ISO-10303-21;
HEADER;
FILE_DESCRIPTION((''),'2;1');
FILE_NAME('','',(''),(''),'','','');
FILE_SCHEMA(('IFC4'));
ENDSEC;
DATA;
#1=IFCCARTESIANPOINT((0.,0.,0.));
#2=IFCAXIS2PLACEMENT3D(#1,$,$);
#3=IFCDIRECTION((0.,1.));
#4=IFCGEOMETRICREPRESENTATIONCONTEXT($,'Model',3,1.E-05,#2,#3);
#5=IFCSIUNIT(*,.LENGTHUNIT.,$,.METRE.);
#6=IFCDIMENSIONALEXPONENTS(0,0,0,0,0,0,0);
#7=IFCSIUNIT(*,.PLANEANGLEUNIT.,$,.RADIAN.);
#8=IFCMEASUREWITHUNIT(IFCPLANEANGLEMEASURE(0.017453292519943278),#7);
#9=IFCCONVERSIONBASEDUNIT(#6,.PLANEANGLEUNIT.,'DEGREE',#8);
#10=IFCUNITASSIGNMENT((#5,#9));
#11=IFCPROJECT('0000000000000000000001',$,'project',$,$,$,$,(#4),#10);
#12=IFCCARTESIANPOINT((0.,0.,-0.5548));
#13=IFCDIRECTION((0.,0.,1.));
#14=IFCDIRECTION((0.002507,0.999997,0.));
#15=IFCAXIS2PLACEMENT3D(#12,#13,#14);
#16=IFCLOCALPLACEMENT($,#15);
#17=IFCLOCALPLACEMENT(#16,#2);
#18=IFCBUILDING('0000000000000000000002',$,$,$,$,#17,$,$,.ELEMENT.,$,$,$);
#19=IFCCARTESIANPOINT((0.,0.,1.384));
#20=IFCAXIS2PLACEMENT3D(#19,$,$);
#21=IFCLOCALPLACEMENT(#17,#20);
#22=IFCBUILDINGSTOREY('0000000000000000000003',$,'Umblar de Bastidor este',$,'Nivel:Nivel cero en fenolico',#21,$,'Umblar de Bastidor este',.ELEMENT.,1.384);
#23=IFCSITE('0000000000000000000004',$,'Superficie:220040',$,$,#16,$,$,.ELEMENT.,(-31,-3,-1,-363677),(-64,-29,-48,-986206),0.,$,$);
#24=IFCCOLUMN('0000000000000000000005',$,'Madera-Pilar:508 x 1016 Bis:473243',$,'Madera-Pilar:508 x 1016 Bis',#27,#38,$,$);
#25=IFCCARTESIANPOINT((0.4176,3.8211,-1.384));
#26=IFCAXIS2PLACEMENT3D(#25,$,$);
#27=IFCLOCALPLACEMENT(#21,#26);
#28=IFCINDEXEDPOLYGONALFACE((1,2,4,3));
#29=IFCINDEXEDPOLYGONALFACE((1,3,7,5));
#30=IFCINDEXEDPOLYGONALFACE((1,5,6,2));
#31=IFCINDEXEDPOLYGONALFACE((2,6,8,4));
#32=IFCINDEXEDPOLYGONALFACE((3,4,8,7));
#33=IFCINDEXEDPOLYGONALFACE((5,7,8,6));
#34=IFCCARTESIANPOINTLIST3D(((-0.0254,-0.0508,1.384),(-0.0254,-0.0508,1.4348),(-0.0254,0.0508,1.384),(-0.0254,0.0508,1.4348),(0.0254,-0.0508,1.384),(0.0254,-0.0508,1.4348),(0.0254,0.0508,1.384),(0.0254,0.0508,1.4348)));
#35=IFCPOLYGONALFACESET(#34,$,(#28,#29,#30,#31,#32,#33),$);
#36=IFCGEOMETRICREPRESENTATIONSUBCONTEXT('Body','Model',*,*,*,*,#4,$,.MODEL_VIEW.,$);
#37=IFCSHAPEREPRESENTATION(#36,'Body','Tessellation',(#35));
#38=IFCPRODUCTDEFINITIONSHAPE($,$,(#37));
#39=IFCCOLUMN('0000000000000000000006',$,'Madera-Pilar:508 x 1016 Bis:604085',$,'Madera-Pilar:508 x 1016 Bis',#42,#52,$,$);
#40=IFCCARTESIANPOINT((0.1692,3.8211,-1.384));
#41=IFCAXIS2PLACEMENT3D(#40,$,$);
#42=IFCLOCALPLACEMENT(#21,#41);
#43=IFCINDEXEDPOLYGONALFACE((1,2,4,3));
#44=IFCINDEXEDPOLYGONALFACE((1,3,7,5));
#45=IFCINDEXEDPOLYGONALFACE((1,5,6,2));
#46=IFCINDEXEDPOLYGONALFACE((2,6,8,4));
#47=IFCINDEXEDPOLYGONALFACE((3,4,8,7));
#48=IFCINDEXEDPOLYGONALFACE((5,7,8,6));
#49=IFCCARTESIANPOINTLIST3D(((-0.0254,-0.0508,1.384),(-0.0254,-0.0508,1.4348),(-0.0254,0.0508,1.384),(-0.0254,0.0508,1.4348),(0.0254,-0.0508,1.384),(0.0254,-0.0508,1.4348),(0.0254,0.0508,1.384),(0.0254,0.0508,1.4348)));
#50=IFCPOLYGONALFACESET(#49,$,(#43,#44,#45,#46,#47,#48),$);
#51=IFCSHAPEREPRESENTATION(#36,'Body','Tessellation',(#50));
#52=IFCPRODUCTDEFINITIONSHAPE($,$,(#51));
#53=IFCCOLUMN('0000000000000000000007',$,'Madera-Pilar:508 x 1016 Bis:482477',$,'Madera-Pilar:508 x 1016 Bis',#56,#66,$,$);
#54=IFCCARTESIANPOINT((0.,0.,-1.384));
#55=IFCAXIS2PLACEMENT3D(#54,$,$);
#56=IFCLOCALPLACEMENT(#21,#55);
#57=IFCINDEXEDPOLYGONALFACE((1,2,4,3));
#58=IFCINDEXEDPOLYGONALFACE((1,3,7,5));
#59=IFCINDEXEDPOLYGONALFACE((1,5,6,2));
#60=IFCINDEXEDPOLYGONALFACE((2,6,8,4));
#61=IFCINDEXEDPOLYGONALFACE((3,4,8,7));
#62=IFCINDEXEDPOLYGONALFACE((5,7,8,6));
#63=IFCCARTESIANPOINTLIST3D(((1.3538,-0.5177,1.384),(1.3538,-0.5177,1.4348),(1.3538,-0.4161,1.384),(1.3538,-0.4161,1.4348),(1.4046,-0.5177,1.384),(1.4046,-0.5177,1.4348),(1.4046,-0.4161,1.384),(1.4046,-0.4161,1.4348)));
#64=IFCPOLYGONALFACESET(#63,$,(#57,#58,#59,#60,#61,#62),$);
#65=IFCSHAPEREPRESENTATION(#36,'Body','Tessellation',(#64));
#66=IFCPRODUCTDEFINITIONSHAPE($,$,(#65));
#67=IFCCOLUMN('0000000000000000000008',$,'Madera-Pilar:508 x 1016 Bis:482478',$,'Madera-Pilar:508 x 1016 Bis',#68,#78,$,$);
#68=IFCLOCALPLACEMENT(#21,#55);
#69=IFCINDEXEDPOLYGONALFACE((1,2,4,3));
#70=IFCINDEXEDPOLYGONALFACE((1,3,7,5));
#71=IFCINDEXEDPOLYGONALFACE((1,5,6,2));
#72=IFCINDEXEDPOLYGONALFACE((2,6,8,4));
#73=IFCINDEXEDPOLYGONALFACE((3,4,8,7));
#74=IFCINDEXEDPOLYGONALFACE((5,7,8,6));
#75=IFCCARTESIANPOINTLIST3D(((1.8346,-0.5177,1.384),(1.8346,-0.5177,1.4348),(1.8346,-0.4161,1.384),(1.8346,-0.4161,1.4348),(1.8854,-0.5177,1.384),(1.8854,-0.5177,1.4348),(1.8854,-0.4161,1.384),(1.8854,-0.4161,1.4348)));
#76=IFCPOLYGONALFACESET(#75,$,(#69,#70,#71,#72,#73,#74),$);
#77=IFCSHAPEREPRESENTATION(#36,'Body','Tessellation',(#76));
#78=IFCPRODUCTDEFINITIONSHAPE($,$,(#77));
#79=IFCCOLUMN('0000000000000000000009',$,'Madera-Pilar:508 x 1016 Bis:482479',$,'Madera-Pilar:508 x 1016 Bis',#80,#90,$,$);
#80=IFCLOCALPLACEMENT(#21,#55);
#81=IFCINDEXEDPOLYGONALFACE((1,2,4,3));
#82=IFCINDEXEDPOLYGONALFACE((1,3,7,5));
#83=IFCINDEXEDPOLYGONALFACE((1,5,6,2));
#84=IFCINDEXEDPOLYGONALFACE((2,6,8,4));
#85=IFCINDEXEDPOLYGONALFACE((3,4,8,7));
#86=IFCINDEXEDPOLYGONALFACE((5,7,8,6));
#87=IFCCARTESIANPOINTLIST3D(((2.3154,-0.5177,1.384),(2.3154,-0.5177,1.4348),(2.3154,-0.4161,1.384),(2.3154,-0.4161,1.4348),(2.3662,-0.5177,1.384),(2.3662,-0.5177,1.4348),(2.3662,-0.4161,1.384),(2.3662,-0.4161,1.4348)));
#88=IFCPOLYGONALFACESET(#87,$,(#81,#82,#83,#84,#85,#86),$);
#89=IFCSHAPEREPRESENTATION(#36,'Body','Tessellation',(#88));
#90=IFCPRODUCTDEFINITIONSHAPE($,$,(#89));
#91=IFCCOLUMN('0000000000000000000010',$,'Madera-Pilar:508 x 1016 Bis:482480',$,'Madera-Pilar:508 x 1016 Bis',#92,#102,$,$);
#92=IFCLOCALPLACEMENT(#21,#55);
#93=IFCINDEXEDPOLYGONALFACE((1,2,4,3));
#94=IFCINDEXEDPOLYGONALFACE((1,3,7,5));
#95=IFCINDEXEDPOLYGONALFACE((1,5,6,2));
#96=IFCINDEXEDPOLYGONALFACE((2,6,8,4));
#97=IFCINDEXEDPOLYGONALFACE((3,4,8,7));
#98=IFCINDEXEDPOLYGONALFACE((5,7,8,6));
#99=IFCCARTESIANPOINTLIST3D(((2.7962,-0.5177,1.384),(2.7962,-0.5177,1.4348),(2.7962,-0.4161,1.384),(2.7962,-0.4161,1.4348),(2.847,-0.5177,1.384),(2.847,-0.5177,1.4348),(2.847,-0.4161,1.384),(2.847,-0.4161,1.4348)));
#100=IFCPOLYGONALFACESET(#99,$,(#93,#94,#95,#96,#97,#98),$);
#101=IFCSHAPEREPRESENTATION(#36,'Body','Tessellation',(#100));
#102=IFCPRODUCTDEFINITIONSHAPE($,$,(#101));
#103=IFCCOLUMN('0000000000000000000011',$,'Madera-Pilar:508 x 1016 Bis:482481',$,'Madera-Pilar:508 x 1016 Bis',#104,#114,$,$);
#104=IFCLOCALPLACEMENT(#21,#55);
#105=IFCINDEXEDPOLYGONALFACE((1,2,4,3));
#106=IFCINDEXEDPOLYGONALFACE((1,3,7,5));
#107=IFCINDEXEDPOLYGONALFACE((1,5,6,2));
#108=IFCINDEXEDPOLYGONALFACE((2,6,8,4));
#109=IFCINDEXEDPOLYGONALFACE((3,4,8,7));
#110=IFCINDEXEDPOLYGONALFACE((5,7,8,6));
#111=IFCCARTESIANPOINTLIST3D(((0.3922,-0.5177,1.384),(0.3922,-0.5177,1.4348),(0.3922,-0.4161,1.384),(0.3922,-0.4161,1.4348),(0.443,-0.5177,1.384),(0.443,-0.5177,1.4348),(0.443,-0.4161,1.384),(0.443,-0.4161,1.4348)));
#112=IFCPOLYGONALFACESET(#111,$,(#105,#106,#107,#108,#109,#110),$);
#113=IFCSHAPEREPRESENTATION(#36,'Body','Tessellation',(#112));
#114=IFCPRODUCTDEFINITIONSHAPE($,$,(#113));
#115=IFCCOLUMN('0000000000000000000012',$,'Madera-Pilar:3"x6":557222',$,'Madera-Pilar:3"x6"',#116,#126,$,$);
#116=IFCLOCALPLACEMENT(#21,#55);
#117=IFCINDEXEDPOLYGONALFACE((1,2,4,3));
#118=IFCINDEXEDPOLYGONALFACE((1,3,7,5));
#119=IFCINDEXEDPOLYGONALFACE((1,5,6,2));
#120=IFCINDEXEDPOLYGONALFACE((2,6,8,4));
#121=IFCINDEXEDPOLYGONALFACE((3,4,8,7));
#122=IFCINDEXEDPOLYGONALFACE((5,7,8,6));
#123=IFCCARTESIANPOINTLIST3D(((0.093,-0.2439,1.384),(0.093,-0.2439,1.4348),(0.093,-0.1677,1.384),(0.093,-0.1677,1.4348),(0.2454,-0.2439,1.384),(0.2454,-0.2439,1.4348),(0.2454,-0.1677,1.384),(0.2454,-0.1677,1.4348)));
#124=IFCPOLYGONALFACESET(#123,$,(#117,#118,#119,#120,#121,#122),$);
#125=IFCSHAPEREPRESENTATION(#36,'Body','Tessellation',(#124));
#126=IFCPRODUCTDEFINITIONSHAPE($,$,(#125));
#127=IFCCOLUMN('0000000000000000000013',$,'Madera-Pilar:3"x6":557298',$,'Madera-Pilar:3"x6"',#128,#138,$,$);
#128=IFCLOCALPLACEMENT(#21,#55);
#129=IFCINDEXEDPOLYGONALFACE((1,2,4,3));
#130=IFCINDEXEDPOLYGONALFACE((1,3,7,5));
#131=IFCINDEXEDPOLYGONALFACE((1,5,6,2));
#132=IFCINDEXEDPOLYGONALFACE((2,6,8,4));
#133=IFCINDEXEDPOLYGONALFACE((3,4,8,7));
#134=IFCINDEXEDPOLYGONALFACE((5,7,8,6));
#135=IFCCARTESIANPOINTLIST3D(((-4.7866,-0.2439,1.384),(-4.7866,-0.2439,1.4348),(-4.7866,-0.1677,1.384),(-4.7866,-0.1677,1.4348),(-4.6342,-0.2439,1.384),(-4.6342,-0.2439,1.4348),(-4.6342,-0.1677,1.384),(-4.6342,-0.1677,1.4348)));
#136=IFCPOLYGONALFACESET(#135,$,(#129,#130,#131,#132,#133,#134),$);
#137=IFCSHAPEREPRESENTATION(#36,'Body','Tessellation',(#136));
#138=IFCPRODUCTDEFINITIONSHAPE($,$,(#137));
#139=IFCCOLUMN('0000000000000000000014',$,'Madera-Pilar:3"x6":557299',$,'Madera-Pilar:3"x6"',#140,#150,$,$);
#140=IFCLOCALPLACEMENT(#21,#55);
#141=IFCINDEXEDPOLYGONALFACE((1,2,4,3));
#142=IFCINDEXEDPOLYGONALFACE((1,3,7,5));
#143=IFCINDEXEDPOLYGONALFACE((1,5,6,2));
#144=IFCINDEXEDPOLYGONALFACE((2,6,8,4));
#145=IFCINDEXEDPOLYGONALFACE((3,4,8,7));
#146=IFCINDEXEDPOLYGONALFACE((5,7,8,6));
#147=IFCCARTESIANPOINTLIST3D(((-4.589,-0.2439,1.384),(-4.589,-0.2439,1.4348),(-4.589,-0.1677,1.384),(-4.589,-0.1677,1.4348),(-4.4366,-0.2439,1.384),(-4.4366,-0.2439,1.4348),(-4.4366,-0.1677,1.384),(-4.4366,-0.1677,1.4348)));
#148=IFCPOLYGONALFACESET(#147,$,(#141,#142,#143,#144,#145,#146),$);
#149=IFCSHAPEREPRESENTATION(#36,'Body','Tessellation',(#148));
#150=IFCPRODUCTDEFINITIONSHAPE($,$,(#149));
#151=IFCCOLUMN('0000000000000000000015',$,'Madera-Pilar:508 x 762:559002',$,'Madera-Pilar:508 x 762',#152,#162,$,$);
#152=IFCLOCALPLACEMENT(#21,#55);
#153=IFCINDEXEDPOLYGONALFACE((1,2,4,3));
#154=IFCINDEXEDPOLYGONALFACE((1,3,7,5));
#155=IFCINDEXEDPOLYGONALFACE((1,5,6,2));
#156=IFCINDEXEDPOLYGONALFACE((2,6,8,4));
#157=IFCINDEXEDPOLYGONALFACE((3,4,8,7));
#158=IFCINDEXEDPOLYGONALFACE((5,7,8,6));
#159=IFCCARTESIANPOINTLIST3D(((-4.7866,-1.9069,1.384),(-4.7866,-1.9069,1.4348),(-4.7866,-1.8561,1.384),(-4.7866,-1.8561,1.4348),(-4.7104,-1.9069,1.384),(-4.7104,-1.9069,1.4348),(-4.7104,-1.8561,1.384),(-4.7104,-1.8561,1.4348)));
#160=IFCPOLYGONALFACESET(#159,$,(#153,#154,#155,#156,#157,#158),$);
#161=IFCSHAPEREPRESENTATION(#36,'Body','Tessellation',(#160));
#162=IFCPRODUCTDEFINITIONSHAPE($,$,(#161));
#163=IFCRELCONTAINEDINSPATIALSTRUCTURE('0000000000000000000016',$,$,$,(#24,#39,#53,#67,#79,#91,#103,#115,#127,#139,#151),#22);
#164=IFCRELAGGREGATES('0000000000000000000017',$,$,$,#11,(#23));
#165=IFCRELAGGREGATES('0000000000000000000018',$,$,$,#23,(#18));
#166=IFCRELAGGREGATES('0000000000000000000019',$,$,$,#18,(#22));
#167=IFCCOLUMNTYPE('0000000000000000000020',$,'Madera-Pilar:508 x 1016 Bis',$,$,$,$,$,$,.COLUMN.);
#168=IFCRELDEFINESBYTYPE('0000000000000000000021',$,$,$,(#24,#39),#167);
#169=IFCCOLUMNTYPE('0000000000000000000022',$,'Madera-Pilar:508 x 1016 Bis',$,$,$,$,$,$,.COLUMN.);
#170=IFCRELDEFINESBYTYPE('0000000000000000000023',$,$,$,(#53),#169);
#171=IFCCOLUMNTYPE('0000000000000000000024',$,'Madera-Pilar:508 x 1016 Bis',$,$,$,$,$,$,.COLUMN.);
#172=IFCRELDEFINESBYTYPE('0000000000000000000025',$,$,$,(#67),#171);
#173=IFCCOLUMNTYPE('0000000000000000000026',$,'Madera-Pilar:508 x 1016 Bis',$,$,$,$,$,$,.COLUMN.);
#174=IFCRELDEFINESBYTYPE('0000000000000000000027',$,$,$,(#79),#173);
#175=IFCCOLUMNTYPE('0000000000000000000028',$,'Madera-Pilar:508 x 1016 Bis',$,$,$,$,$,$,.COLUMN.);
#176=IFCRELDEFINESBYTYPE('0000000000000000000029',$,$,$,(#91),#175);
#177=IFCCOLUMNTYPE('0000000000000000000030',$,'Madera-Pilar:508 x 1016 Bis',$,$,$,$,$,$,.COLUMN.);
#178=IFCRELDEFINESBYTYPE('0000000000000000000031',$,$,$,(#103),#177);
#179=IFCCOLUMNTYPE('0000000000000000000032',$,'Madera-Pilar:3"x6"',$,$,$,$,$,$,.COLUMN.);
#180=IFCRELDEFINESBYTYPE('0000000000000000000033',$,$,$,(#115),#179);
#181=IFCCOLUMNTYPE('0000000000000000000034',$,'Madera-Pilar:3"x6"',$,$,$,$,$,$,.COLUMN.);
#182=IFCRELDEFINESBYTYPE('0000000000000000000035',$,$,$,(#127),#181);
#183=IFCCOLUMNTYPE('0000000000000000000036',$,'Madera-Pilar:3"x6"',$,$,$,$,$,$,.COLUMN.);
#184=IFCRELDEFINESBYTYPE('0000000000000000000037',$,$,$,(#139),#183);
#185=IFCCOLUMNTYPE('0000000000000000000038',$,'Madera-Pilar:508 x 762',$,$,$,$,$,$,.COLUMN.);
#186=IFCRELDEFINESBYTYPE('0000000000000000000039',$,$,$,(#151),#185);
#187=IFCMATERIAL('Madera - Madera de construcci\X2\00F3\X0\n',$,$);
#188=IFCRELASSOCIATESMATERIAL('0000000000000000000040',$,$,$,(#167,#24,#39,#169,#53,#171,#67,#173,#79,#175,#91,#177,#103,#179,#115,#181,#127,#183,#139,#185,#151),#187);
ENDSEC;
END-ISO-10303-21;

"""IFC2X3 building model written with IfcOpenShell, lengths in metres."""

from ifc_helpers import new_model, entity, si_unit, converted_unit, direction, frame, frame_2d, origin, origin_2d_with_axis, place, context, subcontext, project, spatial, rectangle, extrude, source, transform, mapped, material, type_object, type_shapes, element, save


model = new_model("IFC2X3")

# Units and contexts
model_context = context("Model", 3, precision=1e-05, world=origin(), true_north=direction((0.0, 1.0)))
body_context = subcontext(model_context, "Body", "Model", "MODEL_VIEW")
ifc_project = project(units=[si_unit("LENGTHUNIT", "METRE"), converted_unit("PLANEANGLEUNIT", "DEGREE", entity("IfcPlaneAngleMeasure", 0.017453292519943278), si_unit("PLANEANGLEUNIT", "RADIAN"), dimensions=[0, 0, 0, 0, 0, 0, 0])], contexts=[model_context])

# Site, building, storey
site_placement = place(None, frame((0.0, 0.0, -0.5548), z_axis=(0.0, 0.0, 1.0), x_axis=(0.002507, 0.999997, 0.0)))
site = spatial("IfcSite", under=ifc_project, at=site_placement, Name="Superficie:220040", CompositionType="ELEMENT", RefLatitude=(-31, -3, -1, -363677), RefLongitude=(-64, -29, -48, -986206), RefElevation=0.0)
building_placement = place(site_placement, origin())
building = spatial("IfcBuilding", under=site, at=building_placement, CompositionType="ELEMENT")
storey_placement = place(building_placement, frame((0.0, 0.0, 1.384)))
storey = spatial("IfcBuildingStorey", under=building, at=storey_placement, Name="Umblar de Bastidor este", ObjectType="Nivel:Nivel cero en fenolico", LongName="Umblar de Bastidor este", CompositionType="ELEMENT", Elevation=1.384)

# Columns
ifc_material_1 = material(Name="Madera - Madera de construcción")
column_type_1 = type_object("IfcColumnType", Name="Madera-Pilar:508 x 1016 Bis", PredefinedType="COLUMN", material=ifc_material_1)
shared_shape_1 = source(origin(), body_context, "Body", "SweptSolid", [
    extrude(rectangle(XDim=0.0508, YDim=0.1016, at=origin_2d_with_axis()), frame((0.0, 0.0, 1.384), z_axis=(0.0, 0.0, 1.0), x_axis=(-1.0, 0.0, 0.0)), (0.0, 0.0, 1.0), 0.0508),
])
type_shapes(column_type_1, [shared_shape_1])
for number, where, name in (
    (1, (0.4176, 3.8211, -1.384), "Madera-Pilar:508 x 1016 Bis:473243"),
    (2, (0.1692, 3.8211, -1.384), "Madera-Pilar:508 x 1016 Bis:604085"),
):
    element("IfcColumn", number, at=place(storey_placement, frame(where)), inside=storey, type_object=column_type_1, material=ifc_material_1, Name=name, ObjectType="Madera-Pilar:508 x 1016 Bis", context=body_context, shape_type="MappedRepresentation", body=[
        mapped(shared_shape_1, transform((0.0, 0.0, 0.0), scale=1.0)),
    ])
column_type_2 = type_object("IfcColumnType", Name="Madera-Pilar:508 x 1016 Bis", PredefinedType="COLUMN", material=ifc_material_1)
shared_shape_2 = source(origin(), body_context, "Body", "SweptSolid", [
    extrude(rectangle(XDim=0.0508, YDim=0.1016, at=frame_2d((0.0, 0.0), x_axis=(1.0, 0.0))), frame((1.3792, -0.4669, 1.384)), (0.0, 0.0, 1.0), 0.0508),
])
type_shapes(column_type_2, [shared_shape_2])
column_1_placement = place(storey_placement, frame((0.0, 0.0, -1.384)))
element("IfcColumn", 3, at=column_1_placement, inside=storey, type_object=column_type_2, material=ifc_material_1, Name="Madera-Pilar:508 x 1016 Bis:482477", ObjectType="Madera-Pilar:508 x 1016 Bis", context=body_context, shape_type="MappedRepresentation", body=[
    mapped(shared_shape_2, transform((0.0, 0.0, 0.0), scale=1.0)),
])
column_type_3 = type_object("IfcColumnType", Name="Madera-Pilar:508 x 1016 Bis", PredefinedType="COLUMN", material=ifc_material_1)
shared_shape_3 = source(origin(), body_context, "Body", "SweptSolid", [
    extrude(rectangle(XDim=0.0508, YDim=0.1016, at=frame_2d((0.0, 0.0), x_axis=(1.0, 0.0))), frame((1.86, -0.4669, 1.384)), (0.0, 0.0, 1.0), 0.0508),
])
type_shapes(column_type_3, [shared_shape_3])
column_2_placement = place(storey_placement, frame((0.0, 0.0, -1.384)))
element("IfcColumn", 4, at=column_2_placement, inside=storey, type_object=column_type_3, material=ifc_material_1, Name="Madera-Pilar:508 x 1016 Bis:482478", ObjectType="Madera-Pilar:508 x 1016 Bis", context=body_context, shape_type="MappedRepresentation", body=[
    mapped(shared_shape_3, transform((0.0, 0.0, 0.0), scale=1.0)),
])
column_type_4 = type_object("IfcColumnType", Name="Madera-Pilar:508 x 1016 Bis", PredefinedType="COLUMN", material=ifc_material_1)
shared_shape_4 = source(origin(), body_context, "Body", "SweptSolid", [
    extrude(rectangle(XDim=0.0508, YDim=0.1016, at=frame_2d((0.0, 0.0), x_axis=(1.0, 0.0))), frame((2.3408, -0.4669, 1.384)), (0.0, 0.0, 1.0), 0.0508),
])
type_shapes(column_type_4, [shared_shape_4])
column_3_placement = place(storey_placement, frame((0.0, 0.0, -1.384)))
element("IfcColumn", 5, at=column_3_placement, inside=storey, type_object=column_type_4, material=ifc_material_1, Name="Madera-Pilar:508 x 1016 Bis:482479", ObjectType="Madera-Pilar:508 x 1016 Bis", context=body_context, shape_type="MappedRepresentation", body=[
    mapped(shared_shape_4, transform((0.0, 0.0, 0.0), scale=1.0)),
])
column_type_5 = type_object("IfcColumnType", Name="Madera-Pilar:508 x 1016 Bis", PredefinedType="COLUMN", material=ifc_material_1)
shared_shape_5 = source(origin(), body_context, "Body", "SweptSolid", [
    extrude(rectangle(XDim=0.0508, YDim=0.1016, at=frame_2d((0.0, 0.0), x_axis=(1.0, 0.0))), frame((2.8216, -0.4669, 1.384)), (0.0, 0.0, 1.0), 0.0508),
])
type_shapes(column_type_5, [shared_shape_5])
column_4_placement = place(storey_placement, frame((0.0, 0.0, -1.384)))
element("IfcColumn", 6, at=column_4_placement, inside=storey, type_object=column_type_5, material=ifc_material_1, Name="Madera-Pilar:508 x 1016 Bis:482480", ObjectType="Madera-Pilar:508 x 1016 Bis", context=body_context, shape_type="MappedRepresentation", body=[
    mapped(shared_shape_5, transform((0.0, 0.0, 0.0), scale=1.0)),
])
column_type_6 = type_object("IfcColumnType", Name="Madera-Pilar:508 x 1016 Bis", PredefinedType="COLUMN", material=ifc_material_1)
shared_shape_6 = source(origin(), body_context, "Body", "SweptSolid", [
    extrude(rectangle(XDim=0.0508, YDim=0.1016, at=frame_2d((0.0, 0.0), x_axis=(1.0, 0.0))), frame((0.4176, -0.4669, 1.384)), (0.0, 0.0, 1.0), 0.0508),
])
type_shapes(column_type_6, [shared_shape_6])
column_5_placement = place(storey_placement, frame((0.0, 0.0, -1.384)))
element("IfcColumn", 7, at=column_5_placement, inside=storey, type_object=column_type_6, material=ifc_material_1, Name="Madera-Pilar:508 x 1016 Bis:482481", ObjectType="Madera-Pilar:508 x 1016 Bis", context=body_context, shape_type="MappedRepresentation", body=[
    mapped(shared_shape_6, transform((0.0, 0.0, 0.0), scale=1.0)),
])
column_type_7 = type_object("IfcColumnType", Name="Madera-Pilar:3\"x6\"", PredefinedType="COLUMN", material=ifc_material_1)
shared_shape_7 = source(origin(), body_context, "Body", "SweptSolid", [
    extrude(rectangle(XDim=0.1524, YDim=0.0762, at=frame_2d((0.0, 0.0), x_axis=(1.0, 0.0))), frame((0.1692, -0.2058, 1.384), z_axis=(0.0, 0.0, 1.0), x_axis=(-1.0, 0.0, 0.0)), (0.0, 0.0, 1.0), 0.0508),
])
type_shapes(column_type_7, [shared_shape_7])
column_6_placement = place(storey_placement, frame((0.0, 0.0, -1.384)))
element("IfcColumn", 8, at=column_6_placement, inside=storey, type_object=column_type_7, material=ifc_material_1, Name="Madera-Pilar:3\"x6\":557222", ObjectType="Madera-Pilar:3\"x6\"", context=body_context, shape_type="MappedRepresentation", body=[
    mapped(shared_shape_7, transform((0.0, 0.0, 0.0), scale=1.0)),
])
column_type_8 = type_object("IfcColumnType", Name="Madera-Pilar:3\"x6\"", PredefinedType="COLUMN", material=ifc_material_1)
shared_shape_8 = source(origin(), body_context, "Body", "SweptSolid", [
    extrude(rectangle(XDim=0.1524, YDim=0.0762, at=frame_2d((0.0, 0.0), x_axis=(1.0, 0.0))), frame((-4.7104, -0.2058, 1.384), z_axis=(0.0, 0.0, 1.0), x_axis=(-1.0, 0.0, 0.0)), (0.0, 0.0, 1.0), 0.0508),
])
type_shapes(column_type_8, [shared_shape_8])
column_7_placement = place(storey_placement, frame((0.0, 0.0, -1.384)))
element("IfcColumn", 9, at=column_7_placement, inside=storey, type_object=column_type_8, material=ifc_material_1, Name="Madera-Pilar:3\"x6\":557298", ObjectType="Madera-Pilar:3\"x6\"", context=body_context, shape_type="MappedRepresentation", body=[
    mapped(shared_shape_8, transform((0.0, 0.0, 0.0), scale=1.0)),
])
column_type_9 = type_object("IfcColumnType", Name="Madera-Pilar:3\"x6\"", PredefinedType="COLUMN", material=ifc_material_1)
shared_shape_9 = source(origin(), body_context, "Body", "SweptSolid", [
    extrude(rectangle(XDim=0.1524, YDim=0.0762, at=frame_2d((0.0, 0.0), x_axis=(1.0, 0.0))), frame((-4.5128, -0.2058, 1.384), z_axis=(0.0, 0.0, 1.0), x_axis=(-1.0, 0.0, 0.0)), (0.0, 0.0, 1.0), 0.0508),
])
type_shapes(column_type_9, [shared_shape_9])
column_8_placement = place(storey_placement, frame((0.0, 0.0, -1.384)))
element("IfcColumn", 10, at=column_8_placement, inside=storey, type_object=column_type_9, material=ifc_material_1, Name="Madera-Pilar:3\"x6\":557299", ObjectType="Madera-Pilar:3\"x6\"", context=body_context, shape_type="MappedRepresentation", body=[
    mapped(shared_shape_9, transform((0.0, 0.0, 0.0), scale=1.0)),
])
column_type_10 = type_object("IfcColumnType", Name="Madera-Pilar:508 x 762", PredefinedType="COLUMN", material=ifc_material_1)
shared_shape_10 = source(origin(), body_context, "Body", "SweptSolid", [
    extrude(rectangle(XDim=0.0762, YDim=0.0508, at=origin_2d_with_axis()), frame((-4.7485, -1.8815, 1.384), z_axis=(0.0, 0.0, 1.0), x_axis=(-1.0, 0.0, 0.0)), (0.0, 0.0, 1.0), 0.0508),
])
type_shapes(column_type_10, [shared_shape_10])
column_9_placement = place(storey_placement, frame((0.0, 0.0, -1.384)))
element("IfcColumn", 11, at=column_9_placement, inside=storey, type_object=column_type_10, material=ifc_material_1, Name="Madera-Pilar:508 x 762:559002", ObjectType="Madera-Pilar:508 x 762", context=body_context, shape_type="MappedRepresentation", body=[
    mapped(shared_shape_10, transform((0.0, 0.0, 0.0), scale=1.0)),
])

save(model, "model.ifc")
